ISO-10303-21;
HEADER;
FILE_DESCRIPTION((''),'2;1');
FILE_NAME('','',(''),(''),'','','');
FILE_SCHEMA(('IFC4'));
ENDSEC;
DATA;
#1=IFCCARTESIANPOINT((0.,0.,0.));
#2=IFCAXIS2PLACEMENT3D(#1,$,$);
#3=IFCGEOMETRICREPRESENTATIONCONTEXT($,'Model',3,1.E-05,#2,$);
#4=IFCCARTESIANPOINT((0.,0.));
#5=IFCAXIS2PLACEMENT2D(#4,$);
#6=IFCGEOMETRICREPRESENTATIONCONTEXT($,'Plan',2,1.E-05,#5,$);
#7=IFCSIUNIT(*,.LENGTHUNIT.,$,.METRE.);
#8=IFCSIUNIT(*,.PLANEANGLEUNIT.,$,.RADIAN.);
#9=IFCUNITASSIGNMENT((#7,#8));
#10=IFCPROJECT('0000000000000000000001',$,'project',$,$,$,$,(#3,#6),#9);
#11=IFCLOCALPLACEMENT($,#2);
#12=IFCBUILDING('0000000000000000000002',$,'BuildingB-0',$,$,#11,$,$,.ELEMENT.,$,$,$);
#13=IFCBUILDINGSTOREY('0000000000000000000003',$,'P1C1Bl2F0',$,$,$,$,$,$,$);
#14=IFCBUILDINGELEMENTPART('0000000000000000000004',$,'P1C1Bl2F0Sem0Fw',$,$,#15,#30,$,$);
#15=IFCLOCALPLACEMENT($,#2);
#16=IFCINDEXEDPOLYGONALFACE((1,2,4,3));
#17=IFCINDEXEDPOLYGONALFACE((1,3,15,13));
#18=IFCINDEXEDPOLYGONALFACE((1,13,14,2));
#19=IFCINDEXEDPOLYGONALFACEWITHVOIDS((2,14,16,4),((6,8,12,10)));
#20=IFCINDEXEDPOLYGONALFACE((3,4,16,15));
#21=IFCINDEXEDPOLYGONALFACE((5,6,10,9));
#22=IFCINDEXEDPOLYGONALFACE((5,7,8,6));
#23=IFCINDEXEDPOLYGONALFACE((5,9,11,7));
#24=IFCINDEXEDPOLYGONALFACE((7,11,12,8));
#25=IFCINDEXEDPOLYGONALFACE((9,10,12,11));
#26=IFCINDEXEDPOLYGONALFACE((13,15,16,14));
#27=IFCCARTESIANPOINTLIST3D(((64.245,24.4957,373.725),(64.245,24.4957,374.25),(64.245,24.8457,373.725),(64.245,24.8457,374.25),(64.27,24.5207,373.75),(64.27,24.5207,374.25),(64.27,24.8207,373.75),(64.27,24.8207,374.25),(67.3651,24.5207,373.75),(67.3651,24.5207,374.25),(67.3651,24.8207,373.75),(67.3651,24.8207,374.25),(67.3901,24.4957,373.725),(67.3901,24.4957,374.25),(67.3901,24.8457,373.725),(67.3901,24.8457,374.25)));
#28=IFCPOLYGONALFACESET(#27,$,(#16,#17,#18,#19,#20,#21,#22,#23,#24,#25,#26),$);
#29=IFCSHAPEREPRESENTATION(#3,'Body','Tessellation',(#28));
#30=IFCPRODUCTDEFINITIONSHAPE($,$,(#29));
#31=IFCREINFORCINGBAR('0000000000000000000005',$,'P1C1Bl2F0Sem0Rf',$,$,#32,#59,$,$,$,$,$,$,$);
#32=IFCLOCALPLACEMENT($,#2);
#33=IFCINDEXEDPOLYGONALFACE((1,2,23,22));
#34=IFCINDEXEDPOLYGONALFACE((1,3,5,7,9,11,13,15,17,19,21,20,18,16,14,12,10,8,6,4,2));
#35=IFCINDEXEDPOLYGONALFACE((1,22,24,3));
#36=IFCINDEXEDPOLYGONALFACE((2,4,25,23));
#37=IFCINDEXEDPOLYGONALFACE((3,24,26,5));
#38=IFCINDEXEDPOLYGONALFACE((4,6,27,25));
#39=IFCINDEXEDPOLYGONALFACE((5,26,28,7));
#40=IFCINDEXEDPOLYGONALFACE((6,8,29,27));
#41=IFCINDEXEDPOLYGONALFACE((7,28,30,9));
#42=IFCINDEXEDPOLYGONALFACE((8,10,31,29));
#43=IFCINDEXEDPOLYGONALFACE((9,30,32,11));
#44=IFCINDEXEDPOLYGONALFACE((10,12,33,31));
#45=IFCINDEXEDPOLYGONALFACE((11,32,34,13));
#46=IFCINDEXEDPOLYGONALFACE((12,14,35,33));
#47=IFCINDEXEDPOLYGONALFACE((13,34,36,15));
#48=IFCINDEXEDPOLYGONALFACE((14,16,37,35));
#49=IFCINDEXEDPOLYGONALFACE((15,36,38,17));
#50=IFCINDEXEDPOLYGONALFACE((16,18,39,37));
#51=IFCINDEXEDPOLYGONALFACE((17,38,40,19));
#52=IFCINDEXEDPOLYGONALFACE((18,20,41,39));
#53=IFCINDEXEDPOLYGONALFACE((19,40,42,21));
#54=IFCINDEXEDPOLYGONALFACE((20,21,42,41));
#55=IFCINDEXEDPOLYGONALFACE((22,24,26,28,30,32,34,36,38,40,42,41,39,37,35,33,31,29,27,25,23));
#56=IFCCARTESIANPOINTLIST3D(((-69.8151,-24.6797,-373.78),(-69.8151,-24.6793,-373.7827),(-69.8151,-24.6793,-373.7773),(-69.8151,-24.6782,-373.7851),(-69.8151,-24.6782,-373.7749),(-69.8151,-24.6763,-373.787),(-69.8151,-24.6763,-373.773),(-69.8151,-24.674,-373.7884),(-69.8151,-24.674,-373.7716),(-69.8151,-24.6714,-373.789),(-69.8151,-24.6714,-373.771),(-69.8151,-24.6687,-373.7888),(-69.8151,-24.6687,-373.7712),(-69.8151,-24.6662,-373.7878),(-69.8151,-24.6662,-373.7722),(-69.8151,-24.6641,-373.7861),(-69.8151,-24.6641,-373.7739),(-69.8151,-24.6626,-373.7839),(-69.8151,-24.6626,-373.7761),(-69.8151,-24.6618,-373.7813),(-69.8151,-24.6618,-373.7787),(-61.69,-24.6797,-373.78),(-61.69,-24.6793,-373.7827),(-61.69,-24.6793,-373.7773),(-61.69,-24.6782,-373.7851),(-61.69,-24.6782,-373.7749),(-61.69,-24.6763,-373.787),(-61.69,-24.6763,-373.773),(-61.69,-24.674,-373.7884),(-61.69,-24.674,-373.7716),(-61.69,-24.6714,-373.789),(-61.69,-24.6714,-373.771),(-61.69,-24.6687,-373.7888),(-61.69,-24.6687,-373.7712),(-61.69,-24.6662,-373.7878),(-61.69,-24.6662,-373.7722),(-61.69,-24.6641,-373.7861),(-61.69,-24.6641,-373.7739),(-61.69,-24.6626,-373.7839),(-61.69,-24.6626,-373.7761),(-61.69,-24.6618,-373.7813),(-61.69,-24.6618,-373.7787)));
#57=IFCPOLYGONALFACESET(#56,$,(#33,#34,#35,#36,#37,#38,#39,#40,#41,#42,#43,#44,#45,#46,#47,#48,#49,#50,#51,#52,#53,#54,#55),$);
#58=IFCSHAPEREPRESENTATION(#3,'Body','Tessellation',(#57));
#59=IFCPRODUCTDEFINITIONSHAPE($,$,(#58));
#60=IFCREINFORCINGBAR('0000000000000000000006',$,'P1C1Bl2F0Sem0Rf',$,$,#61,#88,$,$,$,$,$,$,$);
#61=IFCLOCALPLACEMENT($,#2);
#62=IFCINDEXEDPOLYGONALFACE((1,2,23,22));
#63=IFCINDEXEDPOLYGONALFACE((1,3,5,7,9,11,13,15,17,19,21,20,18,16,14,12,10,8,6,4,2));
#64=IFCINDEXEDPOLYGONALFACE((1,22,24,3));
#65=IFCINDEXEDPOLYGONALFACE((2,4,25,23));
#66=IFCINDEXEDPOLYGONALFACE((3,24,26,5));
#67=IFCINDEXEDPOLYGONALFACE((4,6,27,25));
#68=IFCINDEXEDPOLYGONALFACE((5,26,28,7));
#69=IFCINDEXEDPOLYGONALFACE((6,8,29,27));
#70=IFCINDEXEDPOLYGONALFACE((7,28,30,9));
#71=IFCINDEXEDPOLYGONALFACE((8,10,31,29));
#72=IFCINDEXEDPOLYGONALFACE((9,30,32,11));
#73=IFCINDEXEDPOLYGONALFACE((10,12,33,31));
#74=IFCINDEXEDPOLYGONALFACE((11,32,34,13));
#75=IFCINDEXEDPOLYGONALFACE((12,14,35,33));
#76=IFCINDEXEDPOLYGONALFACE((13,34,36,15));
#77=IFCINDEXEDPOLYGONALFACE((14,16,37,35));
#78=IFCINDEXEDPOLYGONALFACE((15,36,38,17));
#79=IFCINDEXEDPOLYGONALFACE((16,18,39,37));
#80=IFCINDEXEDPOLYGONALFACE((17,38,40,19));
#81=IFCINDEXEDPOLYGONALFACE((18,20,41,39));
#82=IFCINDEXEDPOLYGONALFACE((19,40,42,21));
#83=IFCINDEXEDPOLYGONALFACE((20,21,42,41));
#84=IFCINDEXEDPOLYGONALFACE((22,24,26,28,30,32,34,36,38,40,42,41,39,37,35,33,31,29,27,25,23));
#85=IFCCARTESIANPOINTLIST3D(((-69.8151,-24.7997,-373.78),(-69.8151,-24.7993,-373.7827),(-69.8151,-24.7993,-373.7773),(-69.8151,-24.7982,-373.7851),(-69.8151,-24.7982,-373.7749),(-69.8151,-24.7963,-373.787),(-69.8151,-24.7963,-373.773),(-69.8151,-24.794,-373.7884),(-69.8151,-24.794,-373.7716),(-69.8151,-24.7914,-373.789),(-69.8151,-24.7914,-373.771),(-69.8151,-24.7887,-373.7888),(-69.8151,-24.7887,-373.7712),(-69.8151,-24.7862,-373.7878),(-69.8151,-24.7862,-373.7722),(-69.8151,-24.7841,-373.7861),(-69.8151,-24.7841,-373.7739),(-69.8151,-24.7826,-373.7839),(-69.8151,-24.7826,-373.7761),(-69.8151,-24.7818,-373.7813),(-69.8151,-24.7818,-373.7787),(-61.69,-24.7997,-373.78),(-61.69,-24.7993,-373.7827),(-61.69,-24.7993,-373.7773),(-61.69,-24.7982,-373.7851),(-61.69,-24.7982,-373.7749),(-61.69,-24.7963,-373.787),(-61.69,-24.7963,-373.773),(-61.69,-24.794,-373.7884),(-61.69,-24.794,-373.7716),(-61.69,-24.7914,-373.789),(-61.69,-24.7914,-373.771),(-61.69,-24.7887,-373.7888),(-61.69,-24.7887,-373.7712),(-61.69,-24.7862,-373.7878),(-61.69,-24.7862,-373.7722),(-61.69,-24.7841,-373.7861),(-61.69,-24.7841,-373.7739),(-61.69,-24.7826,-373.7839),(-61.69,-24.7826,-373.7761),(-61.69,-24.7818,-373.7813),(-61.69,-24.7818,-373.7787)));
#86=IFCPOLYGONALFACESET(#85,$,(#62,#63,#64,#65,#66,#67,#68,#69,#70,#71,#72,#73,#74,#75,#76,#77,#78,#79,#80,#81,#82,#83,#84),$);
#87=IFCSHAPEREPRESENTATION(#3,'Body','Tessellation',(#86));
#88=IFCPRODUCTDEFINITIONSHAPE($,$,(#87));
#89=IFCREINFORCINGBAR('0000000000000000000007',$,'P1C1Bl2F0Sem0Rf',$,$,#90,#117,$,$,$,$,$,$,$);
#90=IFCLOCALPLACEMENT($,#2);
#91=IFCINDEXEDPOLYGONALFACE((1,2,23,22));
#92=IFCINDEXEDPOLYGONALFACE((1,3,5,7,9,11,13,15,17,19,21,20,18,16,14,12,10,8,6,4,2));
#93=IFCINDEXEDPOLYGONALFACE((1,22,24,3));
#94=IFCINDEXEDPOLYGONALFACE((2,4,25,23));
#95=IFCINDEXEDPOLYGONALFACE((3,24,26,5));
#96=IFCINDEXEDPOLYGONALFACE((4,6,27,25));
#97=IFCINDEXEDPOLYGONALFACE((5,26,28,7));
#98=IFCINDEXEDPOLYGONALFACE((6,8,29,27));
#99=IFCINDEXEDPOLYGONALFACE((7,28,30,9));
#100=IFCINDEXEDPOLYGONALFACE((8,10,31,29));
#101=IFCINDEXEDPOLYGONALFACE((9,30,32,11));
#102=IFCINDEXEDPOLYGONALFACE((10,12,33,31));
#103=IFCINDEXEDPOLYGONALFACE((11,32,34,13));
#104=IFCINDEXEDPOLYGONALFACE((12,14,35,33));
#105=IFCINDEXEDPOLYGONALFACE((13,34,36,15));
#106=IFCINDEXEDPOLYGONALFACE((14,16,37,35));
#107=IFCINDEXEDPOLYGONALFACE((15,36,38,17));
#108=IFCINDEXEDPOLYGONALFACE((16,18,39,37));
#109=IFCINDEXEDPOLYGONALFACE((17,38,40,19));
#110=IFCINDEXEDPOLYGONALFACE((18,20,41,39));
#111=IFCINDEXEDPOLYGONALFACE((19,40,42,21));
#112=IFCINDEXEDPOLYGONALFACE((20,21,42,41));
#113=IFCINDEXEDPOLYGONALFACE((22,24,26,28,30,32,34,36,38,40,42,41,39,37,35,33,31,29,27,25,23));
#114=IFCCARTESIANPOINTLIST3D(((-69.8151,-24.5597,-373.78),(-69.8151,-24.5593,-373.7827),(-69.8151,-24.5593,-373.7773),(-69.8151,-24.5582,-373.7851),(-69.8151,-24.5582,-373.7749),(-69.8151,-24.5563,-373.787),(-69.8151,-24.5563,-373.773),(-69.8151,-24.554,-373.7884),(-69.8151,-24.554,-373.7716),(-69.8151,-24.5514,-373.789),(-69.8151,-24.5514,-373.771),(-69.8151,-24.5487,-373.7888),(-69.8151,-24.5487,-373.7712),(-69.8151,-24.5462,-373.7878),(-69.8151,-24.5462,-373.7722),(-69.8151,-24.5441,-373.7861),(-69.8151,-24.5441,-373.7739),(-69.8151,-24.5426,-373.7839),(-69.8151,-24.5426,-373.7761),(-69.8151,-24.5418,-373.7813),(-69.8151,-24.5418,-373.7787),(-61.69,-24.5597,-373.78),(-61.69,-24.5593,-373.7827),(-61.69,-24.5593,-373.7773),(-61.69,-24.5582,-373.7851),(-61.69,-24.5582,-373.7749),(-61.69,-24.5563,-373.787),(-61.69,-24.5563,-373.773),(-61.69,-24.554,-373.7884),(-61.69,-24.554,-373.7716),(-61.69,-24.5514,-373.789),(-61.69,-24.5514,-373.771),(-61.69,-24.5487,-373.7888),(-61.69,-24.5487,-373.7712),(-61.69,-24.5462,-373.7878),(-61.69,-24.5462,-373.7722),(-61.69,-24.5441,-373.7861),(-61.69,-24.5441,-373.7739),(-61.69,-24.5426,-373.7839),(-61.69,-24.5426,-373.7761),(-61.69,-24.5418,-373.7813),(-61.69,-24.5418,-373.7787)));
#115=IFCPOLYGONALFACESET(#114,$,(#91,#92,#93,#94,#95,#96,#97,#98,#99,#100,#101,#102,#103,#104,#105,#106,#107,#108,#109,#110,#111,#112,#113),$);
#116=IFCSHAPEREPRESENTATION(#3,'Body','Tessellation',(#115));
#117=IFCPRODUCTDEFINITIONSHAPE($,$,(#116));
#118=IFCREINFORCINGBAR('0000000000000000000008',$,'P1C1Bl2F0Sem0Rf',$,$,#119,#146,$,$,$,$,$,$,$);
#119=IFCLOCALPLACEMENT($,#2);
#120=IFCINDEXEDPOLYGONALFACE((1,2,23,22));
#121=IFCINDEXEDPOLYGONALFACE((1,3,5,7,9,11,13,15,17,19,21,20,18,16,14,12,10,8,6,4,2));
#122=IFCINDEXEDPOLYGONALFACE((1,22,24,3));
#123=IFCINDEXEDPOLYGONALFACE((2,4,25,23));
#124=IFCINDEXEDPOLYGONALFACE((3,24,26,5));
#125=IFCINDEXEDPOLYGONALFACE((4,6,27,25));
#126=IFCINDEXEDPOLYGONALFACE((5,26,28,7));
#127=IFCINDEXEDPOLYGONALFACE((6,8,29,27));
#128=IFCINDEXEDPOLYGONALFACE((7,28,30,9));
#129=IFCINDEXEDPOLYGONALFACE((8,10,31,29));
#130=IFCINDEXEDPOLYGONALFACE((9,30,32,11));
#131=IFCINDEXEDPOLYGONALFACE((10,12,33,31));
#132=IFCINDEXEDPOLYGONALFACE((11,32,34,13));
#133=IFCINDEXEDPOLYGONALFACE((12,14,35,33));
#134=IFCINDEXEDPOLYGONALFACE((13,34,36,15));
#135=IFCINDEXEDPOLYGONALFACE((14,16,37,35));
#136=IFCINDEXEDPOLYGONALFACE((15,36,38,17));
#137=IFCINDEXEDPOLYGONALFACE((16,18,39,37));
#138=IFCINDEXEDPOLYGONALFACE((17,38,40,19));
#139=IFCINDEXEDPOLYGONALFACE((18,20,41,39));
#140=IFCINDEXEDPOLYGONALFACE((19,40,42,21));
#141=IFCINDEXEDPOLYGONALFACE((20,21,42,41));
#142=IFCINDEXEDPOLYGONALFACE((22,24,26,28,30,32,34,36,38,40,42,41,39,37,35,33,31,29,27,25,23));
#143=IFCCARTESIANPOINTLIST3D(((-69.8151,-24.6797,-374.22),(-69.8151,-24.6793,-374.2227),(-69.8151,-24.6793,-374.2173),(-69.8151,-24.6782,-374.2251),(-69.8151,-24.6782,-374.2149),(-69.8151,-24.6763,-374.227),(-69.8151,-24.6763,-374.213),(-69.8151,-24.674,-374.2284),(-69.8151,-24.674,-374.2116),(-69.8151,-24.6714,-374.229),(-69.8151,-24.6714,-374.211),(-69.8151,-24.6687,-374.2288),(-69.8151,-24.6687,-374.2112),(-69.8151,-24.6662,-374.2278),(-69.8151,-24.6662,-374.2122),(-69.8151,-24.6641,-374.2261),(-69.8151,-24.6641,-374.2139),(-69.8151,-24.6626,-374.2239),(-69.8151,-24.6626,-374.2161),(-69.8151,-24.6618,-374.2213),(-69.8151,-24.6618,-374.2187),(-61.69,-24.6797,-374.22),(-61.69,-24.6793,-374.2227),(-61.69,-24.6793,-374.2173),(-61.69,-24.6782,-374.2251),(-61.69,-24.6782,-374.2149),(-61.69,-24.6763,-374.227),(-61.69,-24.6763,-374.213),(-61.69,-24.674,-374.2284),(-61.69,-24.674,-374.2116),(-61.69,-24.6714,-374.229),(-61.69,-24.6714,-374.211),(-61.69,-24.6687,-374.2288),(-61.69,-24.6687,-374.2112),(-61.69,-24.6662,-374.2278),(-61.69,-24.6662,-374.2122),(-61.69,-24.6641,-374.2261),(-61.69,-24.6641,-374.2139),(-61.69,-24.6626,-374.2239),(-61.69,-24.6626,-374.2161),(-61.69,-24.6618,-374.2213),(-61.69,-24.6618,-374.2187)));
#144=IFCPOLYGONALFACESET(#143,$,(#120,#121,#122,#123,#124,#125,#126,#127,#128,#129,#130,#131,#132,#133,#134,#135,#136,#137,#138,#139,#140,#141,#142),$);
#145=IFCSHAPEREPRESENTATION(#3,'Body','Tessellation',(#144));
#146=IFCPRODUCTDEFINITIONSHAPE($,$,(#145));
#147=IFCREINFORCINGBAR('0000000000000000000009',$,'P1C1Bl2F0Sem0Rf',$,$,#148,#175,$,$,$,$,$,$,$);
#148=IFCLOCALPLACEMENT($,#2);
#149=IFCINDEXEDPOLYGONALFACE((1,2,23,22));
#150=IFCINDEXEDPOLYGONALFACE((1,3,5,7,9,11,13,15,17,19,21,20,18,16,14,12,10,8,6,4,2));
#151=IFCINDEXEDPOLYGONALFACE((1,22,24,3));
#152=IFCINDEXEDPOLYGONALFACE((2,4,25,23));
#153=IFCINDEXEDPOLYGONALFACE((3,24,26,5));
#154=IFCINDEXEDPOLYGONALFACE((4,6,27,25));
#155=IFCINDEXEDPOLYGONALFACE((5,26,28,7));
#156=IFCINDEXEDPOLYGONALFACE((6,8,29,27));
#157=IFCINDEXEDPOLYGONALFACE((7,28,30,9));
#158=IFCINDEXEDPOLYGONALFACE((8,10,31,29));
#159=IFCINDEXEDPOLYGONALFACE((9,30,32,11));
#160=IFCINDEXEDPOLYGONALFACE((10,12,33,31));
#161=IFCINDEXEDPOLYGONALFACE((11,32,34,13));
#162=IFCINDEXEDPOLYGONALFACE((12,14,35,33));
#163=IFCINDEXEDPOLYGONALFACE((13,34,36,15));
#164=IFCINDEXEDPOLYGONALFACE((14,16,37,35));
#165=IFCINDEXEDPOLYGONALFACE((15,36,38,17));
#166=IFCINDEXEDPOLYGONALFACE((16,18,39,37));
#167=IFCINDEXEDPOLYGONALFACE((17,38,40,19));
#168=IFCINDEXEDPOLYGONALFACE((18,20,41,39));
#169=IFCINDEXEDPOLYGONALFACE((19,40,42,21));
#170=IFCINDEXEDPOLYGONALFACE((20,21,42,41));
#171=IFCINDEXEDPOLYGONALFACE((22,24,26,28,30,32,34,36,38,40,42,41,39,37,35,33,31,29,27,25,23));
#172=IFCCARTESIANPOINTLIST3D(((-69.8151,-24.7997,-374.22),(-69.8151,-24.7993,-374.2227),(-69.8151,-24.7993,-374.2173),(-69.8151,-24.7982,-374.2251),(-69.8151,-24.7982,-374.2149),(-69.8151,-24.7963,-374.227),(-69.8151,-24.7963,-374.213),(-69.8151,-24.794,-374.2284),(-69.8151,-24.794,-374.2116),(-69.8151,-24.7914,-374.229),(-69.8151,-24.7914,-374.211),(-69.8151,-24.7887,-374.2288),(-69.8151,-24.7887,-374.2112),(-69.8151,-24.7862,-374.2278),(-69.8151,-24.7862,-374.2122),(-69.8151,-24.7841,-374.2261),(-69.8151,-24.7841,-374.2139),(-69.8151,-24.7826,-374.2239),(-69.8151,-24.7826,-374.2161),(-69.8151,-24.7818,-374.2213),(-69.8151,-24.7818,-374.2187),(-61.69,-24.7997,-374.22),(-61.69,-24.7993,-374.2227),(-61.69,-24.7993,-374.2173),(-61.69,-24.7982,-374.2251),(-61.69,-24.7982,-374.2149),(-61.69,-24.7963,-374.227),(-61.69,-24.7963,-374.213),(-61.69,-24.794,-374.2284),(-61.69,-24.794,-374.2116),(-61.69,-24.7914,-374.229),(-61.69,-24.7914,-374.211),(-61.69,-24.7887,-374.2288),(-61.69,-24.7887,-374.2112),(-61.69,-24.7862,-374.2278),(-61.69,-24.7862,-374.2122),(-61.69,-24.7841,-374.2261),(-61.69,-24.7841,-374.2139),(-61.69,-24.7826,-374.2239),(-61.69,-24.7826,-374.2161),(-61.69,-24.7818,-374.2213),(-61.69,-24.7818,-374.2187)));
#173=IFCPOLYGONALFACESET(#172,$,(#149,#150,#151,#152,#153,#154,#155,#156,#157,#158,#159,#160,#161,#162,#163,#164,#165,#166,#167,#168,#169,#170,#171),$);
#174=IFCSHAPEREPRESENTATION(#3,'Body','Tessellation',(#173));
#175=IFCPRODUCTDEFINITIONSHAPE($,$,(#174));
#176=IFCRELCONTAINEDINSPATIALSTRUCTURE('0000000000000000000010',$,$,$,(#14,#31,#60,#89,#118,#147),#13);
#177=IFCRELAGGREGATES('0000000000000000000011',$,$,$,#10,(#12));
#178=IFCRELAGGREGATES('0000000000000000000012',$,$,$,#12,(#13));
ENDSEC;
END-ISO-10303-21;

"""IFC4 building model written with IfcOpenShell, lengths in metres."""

from ifc_helpers import new_model, entity, si_unit, origin, origin_2d, place, context, project, spatial, polyline, outline, extrude, element, save


model = new_model("IFC4")

# Units and contexts
model_context = context("Model", 3, precision=1e-05, world=origin())
plan_context = context("Plan", 2, precision=1e-05, world=origin_2d())
ifc_project = project(units=[si_unit("LENGTHUNIT", "METRE"), si_unit("PLANEANGLEUNIT", "RADIAN")], contexts=[model_context, plan_context])

# Building, storey
building_placement = place(None, origin())
building = spatial("IfcBuilding", under=ifc_project, at=building_placement, Name="BuildingB-0", CompositionType="ELEMENT")
storey = spatial("IfcBuildingStorey", under=building, Name="P1C1Bl2F0")

# Building element part, opening
building_element_part_1 = element("IfcBuildingElementPart", 1, inside=storey, Name="P1C1Bl2F0Sem0Fw", context=model_context, shape_type="SweptSolid", body=[
    extrude(outline(polyline([(67.3901, 24.4957, 373.725), (67.3901, 24.8457, 373.725), (64.245, 24.8457, 373.725), (64.245, 24.4957, 373.725), (67.3901, 24.4957, 373.725)])), None, (0.0, 0.0, 1.0), 0.525),
])
element("IfcOpeningElement", 2, inside=storey, cuts=building_element_part_1, context=model_context, shape_type="SweptSolid", body=[
    extrude(outline(polyline([(67.3651, 24.5207, 373.75), (67.3651, 24.8207, 373.75), (64.27, 24.8207, 373.75), (64.27, 24.5207, 373.75), (67.3651, 24.5207, 373.75)])), None, (0.0, 0.0, 1.0), 0.5),
])

# Reinforcing bars
element("IfcReinforcingBar", 3, inside=storey, Name="P1C1Bl2F0Sem0Rf", context=model_context, shape_type="SweptSolid", body=[
    entity("IfcSurfaceCurveSweptAreaSolid", entity("IfcCircleProfileDef", "AREA", None, None, 0.009), None, entity("IfcPolyline", [entity("IfcCartesianPoint", [69.8151, 24.6707, 373.78]), entity("IfcCartesianPoint", [61.69, 24.6707, 373.78])]), None, None, entity("IfcPlane", entity("IfcAxis2Placement3D", entity("IfcCartesianPoint", [69.8151, 24.6707, 373.78]), entity("IfcDirection", [0.0, 0.0, 1.0]), entity("IfcDirection", [1.0, 0.0, 0.0])))),
])
element("IfcReinforcingBar", 4, inside=storey, Name="P1C1Bl2F0Sem0Rf", context=model_context, shape_type="SweptSolid", body=[
    entity("IfcSurfaceCurveSweptAreaSolid", entity("IfcCircleProfileDef", "AREA", None, None, 0.009), None, entity("IfcPolyline", [entity("IfcCartesianPoint", [69.8151, 24.7907, 373.78]), entity("IfcCartesianPoint", [61.69, 24.7907, 373.78])]), None, None, entity("IfcPlane", entity("IfcAxis2Placement3D", entity("IfcCartesianPoint", [69.8151, 24.7907, 373.78]), entity("IfcDirection", [0.0, 0.0, 1.0]), entity("IfcDirection", [1.0, 0.0, 0.0])))),
])
element("IfcReinforcingBar", 5, inside=storey, Name="P1C1Bl2F0Sem0Rf", context=model_context, shape_type="SweptSolid", body=[
    entity("IfcSurfaceCurveSweptAreaSolid", entity("IfcCircleProfileDef", "AREA", None, None, 0.009), None, entity("IfcPolyline", [entity("IfcCartesianPoint", [69.8151, 24.5507, 373.78]), entity("IfcCartesianPoint", [61.69, 24.5507, 373.78])]), None, None, entity("IfcPlane", entity("IfcAxis2Placement3D", entity("IfcCartesianPoint", [69.8151, 24.5507, 373.78]), entity("IfcDirection", [0.0, 0.0, 1.0]), entity("IfcDirection", [1.0, 0.0, 0.0])))),
])
element("IfcReinforcingBar", 6, inside=storey, Name="P1C1Bl2F0Sem0Rf", context=model_context, shape_type="SweptSolid", body=[
    entity("IfcSurfaceCurveSweptAreaSolid", entity("IfcCircleProfileDef", "AREA", None, None, 0.009), None, entity("IfcPolyline", [entity("IfcCartesianPoint", [69.8151, 24.6707, 374.22]), entity("IfcCartesianPoint", [61.69, 24.6707, 374.22])]), None, None, entity("IfcPlane", entity("IfcAxis2Placement3D", entity("IfcCartesianPoint", [69.8151, 24.6707, 374.22]), entity("IfcDirection", [0.0, 0.0, 1.0]), entity("IfcDirection", [1.0, 0.0, 0.0])))),
])
element("IfcReinforcingBar", 7, inside=storey, Name="P1C1Bl2F0Sem0Rf", context=model_context, shape_type="SweptSolid", body=[
    entity("IfcSurfaceCurveSweptAreaSolid", entity("IfcCircleProfileDef", "AREA", None, None, 0.009), None, entity("IfcPolyline", [entity("IfcCartesianPoint", [69.8151, 24.7907, 374.22]), entity("IfcCartesianPoint", [61.69, 24.7907, 374.22])]), None, None, entity("IfcPlane", entity("IfcAxis2Placement3D", entity("IfcCartesianPoint", [69.8151, 24.7907, 374.22]), entity("IfcDirection", [0.0, 0.0, 1.0]), entity("IfcDirection", [1.0, 0.0, 0.0])))),
])

save(model, "model.ifc")
